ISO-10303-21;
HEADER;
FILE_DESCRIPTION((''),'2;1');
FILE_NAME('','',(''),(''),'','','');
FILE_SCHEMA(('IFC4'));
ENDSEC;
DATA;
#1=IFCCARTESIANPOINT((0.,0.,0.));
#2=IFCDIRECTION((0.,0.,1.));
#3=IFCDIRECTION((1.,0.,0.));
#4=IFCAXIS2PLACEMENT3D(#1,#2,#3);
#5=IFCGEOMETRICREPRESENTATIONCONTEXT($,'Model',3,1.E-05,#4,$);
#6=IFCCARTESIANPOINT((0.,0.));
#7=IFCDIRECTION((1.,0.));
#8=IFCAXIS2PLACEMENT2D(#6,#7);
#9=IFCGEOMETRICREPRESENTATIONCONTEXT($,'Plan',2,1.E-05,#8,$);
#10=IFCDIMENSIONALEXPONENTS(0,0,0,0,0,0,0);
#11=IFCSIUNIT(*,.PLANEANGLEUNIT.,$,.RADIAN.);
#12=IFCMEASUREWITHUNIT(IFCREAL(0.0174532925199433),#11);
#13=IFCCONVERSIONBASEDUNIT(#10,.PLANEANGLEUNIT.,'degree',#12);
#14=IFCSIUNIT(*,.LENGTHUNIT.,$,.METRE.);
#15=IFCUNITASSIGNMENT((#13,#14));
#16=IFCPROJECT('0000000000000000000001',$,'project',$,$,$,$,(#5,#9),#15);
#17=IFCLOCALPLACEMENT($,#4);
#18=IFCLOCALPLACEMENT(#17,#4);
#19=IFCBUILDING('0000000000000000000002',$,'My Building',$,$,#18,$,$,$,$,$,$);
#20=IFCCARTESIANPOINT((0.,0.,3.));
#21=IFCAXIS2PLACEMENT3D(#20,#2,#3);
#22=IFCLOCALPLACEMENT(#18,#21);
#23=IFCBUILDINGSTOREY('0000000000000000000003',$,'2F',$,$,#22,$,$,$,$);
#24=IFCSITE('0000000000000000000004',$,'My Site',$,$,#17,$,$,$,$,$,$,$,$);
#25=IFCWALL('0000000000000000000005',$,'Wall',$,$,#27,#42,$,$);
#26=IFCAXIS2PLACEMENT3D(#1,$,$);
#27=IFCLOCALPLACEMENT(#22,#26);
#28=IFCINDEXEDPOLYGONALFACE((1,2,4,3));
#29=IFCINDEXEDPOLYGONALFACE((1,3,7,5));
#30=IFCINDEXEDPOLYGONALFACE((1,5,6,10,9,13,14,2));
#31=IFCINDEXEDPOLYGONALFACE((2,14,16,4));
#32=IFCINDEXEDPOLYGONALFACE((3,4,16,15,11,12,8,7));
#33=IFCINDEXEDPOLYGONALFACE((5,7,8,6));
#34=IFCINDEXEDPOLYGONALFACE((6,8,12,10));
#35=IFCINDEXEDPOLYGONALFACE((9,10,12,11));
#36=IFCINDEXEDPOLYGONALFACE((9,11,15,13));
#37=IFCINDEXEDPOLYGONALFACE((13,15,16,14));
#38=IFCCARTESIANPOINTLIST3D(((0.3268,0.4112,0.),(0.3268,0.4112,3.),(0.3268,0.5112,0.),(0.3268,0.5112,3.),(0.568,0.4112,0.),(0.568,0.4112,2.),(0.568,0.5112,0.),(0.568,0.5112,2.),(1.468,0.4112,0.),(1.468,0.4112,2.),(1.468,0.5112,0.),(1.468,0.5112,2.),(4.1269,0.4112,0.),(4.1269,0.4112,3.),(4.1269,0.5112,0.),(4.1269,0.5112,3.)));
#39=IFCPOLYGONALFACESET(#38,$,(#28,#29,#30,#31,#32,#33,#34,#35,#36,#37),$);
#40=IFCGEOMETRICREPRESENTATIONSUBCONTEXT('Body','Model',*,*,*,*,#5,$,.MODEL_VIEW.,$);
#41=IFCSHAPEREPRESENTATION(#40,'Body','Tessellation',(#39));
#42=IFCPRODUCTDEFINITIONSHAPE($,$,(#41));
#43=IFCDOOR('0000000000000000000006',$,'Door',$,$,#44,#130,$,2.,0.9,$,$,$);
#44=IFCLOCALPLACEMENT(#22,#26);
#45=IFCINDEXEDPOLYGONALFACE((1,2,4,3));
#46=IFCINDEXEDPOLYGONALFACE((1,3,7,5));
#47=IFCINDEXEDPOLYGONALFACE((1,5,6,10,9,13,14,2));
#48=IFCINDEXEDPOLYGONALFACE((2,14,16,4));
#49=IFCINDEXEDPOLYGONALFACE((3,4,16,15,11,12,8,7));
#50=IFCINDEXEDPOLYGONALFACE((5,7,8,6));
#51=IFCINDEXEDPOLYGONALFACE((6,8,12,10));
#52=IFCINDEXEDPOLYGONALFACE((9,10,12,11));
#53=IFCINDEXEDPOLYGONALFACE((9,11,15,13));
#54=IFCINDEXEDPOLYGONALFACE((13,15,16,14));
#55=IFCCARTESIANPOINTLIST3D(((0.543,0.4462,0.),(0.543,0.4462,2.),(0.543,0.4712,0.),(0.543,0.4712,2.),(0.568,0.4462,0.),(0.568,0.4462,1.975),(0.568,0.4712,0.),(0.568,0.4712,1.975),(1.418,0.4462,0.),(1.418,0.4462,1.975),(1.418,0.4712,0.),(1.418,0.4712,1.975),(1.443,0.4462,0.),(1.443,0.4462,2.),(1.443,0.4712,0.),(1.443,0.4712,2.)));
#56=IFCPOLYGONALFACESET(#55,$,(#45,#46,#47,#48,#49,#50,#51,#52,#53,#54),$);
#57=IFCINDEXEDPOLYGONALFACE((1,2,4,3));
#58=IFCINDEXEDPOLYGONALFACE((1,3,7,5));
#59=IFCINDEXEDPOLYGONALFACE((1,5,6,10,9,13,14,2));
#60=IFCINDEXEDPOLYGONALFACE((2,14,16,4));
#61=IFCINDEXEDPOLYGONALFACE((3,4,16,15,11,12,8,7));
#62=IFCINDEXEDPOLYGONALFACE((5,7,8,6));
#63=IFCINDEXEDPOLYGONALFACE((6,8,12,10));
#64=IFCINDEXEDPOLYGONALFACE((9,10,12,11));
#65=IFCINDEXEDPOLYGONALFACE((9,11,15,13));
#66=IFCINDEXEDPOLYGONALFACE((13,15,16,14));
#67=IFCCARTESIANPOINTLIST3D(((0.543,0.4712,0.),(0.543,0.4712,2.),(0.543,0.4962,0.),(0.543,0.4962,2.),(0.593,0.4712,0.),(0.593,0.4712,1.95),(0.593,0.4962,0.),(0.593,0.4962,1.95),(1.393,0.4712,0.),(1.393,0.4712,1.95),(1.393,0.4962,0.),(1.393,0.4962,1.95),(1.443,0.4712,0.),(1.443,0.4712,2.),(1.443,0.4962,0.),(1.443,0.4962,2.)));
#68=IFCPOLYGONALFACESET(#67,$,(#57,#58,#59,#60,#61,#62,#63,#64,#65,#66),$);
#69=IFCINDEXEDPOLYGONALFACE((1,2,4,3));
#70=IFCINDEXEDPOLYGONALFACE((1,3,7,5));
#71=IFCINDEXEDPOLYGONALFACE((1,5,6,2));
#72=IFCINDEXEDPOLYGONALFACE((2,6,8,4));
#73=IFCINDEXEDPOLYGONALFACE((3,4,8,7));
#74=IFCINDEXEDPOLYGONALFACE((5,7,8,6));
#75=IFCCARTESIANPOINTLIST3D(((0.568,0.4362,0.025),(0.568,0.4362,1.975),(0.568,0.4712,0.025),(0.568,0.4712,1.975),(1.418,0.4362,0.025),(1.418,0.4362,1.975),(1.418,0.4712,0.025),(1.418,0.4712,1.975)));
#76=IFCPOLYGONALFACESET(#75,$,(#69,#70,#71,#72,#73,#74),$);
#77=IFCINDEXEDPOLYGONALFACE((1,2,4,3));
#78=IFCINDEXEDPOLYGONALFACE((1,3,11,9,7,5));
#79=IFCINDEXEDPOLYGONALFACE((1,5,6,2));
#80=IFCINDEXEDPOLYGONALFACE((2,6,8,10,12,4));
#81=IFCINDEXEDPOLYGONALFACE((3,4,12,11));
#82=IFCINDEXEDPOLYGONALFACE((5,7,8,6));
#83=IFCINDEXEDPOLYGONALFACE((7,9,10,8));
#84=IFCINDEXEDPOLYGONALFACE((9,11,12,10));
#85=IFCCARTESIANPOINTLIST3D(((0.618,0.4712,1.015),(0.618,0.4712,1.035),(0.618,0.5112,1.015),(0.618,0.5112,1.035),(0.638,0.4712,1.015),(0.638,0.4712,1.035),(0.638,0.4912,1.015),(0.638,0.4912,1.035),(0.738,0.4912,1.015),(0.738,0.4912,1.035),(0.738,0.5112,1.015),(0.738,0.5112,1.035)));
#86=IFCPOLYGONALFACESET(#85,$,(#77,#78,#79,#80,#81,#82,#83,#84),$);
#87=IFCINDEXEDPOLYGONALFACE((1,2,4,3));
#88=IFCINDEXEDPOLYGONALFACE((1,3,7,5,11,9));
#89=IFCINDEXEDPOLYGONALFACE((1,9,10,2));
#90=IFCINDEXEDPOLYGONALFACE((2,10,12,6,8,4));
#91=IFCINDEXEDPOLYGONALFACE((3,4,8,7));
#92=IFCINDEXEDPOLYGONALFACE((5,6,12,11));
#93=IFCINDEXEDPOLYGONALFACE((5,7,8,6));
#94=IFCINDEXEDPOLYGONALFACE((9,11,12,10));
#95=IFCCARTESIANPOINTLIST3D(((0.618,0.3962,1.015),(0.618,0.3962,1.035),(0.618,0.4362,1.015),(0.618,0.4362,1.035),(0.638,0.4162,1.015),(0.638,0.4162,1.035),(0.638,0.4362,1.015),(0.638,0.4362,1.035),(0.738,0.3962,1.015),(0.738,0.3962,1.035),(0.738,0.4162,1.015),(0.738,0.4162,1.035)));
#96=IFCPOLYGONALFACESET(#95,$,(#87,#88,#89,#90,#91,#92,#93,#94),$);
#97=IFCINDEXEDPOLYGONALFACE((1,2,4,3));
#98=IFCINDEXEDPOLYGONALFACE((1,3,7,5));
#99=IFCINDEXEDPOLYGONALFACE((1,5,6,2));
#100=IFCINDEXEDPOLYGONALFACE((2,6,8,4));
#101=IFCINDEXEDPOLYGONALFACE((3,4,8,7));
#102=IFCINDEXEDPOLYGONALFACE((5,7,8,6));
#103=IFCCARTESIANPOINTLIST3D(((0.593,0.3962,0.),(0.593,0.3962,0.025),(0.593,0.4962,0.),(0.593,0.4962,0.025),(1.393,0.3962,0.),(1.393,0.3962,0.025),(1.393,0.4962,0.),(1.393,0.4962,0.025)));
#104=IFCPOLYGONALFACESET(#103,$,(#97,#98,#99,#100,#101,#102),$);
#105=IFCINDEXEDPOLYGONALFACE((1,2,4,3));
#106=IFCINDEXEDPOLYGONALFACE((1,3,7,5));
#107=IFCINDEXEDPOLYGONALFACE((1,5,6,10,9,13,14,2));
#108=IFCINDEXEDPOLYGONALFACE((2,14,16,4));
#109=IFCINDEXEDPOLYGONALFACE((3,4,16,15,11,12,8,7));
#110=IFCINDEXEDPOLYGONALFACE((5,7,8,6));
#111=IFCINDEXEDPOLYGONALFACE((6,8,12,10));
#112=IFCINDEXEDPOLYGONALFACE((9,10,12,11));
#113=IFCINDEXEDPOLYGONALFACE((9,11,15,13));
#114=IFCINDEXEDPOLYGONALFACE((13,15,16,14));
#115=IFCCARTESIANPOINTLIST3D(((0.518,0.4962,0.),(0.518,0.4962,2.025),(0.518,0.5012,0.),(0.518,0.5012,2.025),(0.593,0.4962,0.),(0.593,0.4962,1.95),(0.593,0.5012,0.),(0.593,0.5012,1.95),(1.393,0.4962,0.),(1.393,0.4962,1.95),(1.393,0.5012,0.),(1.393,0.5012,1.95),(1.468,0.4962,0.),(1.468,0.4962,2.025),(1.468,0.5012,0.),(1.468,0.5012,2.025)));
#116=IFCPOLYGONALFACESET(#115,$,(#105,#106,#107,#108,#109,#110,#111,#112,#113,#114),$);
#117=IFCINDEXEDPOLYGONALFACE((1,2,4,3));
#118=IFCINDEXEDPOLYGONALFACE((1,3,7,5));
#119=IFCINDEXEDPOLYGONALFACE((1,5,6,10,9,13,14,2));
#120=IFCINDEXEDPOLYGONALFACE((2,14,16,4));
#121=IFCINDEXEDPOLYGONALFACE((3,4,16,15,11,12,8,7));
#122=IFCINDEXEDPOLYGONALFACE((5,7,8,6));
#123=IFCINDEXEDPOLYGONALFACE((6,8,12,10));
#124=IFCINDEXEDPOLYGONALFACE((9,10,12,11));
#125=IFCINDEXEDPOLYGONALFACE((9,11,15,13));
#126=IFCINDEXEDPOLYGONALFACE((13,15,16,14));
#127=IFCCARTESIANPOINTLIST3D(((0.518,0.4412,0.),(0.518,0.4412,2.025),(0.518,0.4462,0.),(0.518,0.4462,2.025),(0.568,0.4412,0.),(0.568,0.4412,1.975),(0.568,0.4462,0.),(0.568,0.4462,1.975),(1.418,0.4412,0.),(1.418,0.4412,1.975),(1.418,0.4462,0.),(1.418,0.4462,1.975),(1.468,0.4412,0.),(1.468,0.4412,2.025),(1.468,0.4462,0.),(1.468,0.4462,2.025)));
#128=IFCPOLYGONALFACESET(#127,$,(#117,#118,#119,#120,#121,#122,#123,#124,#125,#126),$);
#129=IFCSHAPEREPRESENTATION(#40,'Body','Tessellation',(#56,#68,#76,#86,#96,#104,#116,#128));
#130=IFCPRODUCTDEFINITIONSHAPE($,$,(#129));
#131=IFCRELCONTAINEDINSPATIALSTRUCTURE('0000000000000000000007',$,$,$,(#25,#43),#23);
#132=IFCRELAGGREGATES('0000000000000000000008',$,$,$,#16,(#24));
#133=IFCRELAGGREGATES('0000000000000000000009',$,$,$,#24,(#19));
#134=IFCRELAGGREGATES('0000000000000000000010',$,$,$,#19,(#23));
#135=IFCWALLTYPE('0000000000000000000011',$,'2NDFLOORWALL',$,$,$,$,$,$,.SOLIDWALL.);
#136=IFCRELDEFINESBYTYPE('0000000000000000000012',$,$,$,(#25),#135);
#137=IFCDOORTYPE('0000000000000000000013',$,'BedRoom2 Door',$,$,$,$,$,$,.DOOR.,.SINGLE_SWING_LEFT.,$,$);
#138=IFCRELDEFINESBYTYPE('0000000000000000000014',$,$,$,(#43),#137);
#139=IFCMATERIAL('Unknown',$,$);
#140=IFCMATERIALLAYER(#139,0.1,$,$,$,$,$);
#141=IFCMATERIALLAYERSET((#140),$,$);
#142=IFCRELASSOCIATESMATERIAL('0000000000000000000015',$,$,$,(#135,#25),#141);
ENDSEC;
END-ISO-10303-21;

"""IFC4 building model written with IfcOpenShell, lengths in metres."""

from ifc_helpers import new_model, entity, si_unit, converted_unit, frame, origin_with_axes, origin_2d_with_axis, place, context, subcontext, project, spatial, line, indexed_curve, outline, extrude, shape, source, transform, mapped, material, layer, layer_set, layer_usage, type_object, type_shapes, element, fill, save


model = new_model("IFC4")

# Units and contexts
model_context = context("Model", 3, precision=1e-05, world=origin_with_axes())
plan_context = context("Plan", 2, precision=1e-05, world=origin_2d_with_axis())
body_context_1 = subcontext(model_context, "Body", "Model", "MODEL_VIEW")
body_context_2 = subcontext(plan_context, "Body", "Plan", "PLAN_VIEW")
ifc_project = project(units=[converted_unit("PLANEANGLEUNIT", "degree", entity("IfcReal", 0.0174532925199433), si_unit("PLANEANGLEUNIT", "RADIAN"), dimensions=[0, 0, 0, 0, 0, 0, 0]), si_unit("LENGTHUNIT", "METRE")], contexts=[model_context, plan_context])

# Site, building, storey
site_placement = place(None, origin_with_axes())
site = spatial("IfcSite", under=ifc_project, at=site_placement, Name="My Site")
building_placement = place(site_placement, origin_with_axes())
building = spatial("IfcBuilding", under=site, at=building_placement, Name="My Building")
storey_placement = place(building_placement, frame((0.0, 0.0, 3.0), z_axis=(0.0, 0.0, 1.0), x_axis=(1.0, 0.0, 0.0)))
storey = spatial("IfcBuildingStorey", under=building, at=storey_placement, Name="2F")

# Shared definitions
ifc_material = material(Name="Unknown")

# Shared definitions
ifc_layer_1 = layer(ifc_material, 0.1)
ifc_layer_set_1 = layer_set([ifc_layer_1])
wall_type_1 = type_object("IfcWallType", Name="2NDFLOORWALL", PredefinedType="SOLIDWALL", material=ifc_layer_set_1)

# Wall, opening, door
ifc_layer_usage_1 = layer_usage(ifc_layer_set_1, "AXIS2", "POSITIVE", 0.0)
wall_1_placement = place(storey_placement, frame((0.3268, 0.4112, 0.0), z_axis=(0.0, 0.0, 1.0), x_axis=(1.0, 0.0, 0.0)))
wall_1 = element("IfcWall", 1, at=wall_1_placement, inside=storey, type_object=wall_type_1, material=ifc_layer_usage_1, Name="Wall", context=body_context_1, shape_type="SweptSolid", body=[
    extrude(outline(indexed_curve([(0.0, 0.0), (0.0, 0.1), (3.8001, 0.1), (3.8001, 0.0)], segments=[line(1, 2, 3, 4, 1)])), origin_with_axes(), (0.0, 0.0, 1.0), 3.0),
])
shared_shape_1 = source(origin_with_axes(), body_context_1, "Body", "SweptSolid", [
    extrude(outline(indexed_curve([(0.0, 0.0), (0.9, 0.0), (0.9, 2.0), (0.0, 2.0)], segments=[line(1, 2, 3, 4, 1)])), frame((0.0, -0.6, 0.0), z_axis=(0.0, -1.0, 0.0), x_axis=(1.0, 0.0, 0.0)), (0.0, 0.0, -1.0), 1.2),
])
opening_1_placement = place(wall_1_placement, frame((0.2412, 0.0, 0.0), z_axis=(0.0, 0.0, 1.0), x_axis=(1.0, 0.0, 0.0)))
opening_1 = element("IfcOpeningElement", 2, at=opening_1_placement, cuts=wall_1, PredefinedType="OPENING", context=body_context_1, shape_type="MappedRepresentation", body=[
    mapped(shared_shape_1, transform((0.0, 0.0, 0.0), x_axis=(1.0, 0.0, 0.0), y_axis=(0.0, 1.0, 0.0), z_axis=(0.0, 0.0, 1.0), scale=1.0)),
])
door_type_1 = type_object("IfcDoorType", Name="BedRoom2 Door", OperationType="SINGLE_SWING_LEFT", PredefinedType="DOOR")
shared_shape_2 = source(origin_with_axes(), body_context_1, "Body", "SweptSolid", [
    extrude(outline(indexed_curve([(0.0, 0.0), (0.0, 2.0), (0.9, 2.0), (0.9, 0.0), (0.875, 0.0), (0.875, 1.975), (0.025, 1.975), (0.025, 0.0)], segments=[line(1, 2, 3, 4, 5, 6, 7, 8, 1)])), frame((0.0, 0.025, 0.0), z_axis=(0.0, -1.0, 0.0), x_axis=(1.0, 0.0, 0.0)), (0.0, 0.0, -1.0), 0.025),
    extrude(outline(indexed_curve([(0.0, 0.0), (0.0, 2.0), (0.9, 2.0), (0.9, 0.0), (0.85, 0.0), (0.85, 1.95), (0.05, 1.95), (0.05, 0.0)], segments=[line(1, 2, 3, 4, 5, 6, 7, 8, 1)])), frame((0.0, 0.0, 0.0), z_axis=(0.0, -1.0, 0.0), x_axis=(1.0, 0.0, 0.0)), (0.0, 0.0, -1.0), 0.025),
    extrude(outline(indexed_curve([(0.0, 0.0), (0.85, 0.0), (0.85, 0.035), (0.0, 0.035)], segments=[line(1, 2, 3, 4, 1)])), frame((0.025, 0.025, 0.025), z_axis=(0.0, 0.0, 1.0), x_axis=(1.0, 0.0, 0.0)), (0.0, 0.0, 1.0), 1.95),
    extrude(outline(indexed_curve([(0.0, 0.0), (0.0, -0.04), (-0.12, -0.04), (-0.12, -0.02), (-0.02, -0.02), (-0.02, 0.0)], segments=[line(1, 2, 3, 4, 5, 6, 1)])), frame((0.825, 0.025, 1.015), z_axis=(0.0, 0.0, 1.0), x_axis=(1.0, 0.0, 0.0)), (0.0, 0.0, 1.0), 0.02),
    extrude(outline(indexed_curve([(0.0, 0.0), (0.0, 0.04), (-0.12, 0.04), (-0.12, 0.02), (-0.02, 0.02), (-0.02, 0.0)], segments=[line(1, 2, 3, 4, 5, 6, 1)])), frame((0.825, 0.06, 1.015), z_axis=(0.0, 0.0, 1.0), x_axis=(1.0, 0.0, 0.0)), (0.0, 0.0, 1.0), 0.02),
    extrude(outline(indexed_curve([(0.0, 0.0), (0.8, 0.0), (0.8, 0.1), (0.0, 0.1)], segments=[line(1, 2, 3, 4, 1)])), frame((0.05, 0.0, 0.0), z_axis=(0.0, 0.0, 1.0), x_axis=(1.0, 0.0, 0.0)), (0.0, 0.0, 1.0), 0.025),
    extrude(outline(indexed_curve([(0.0, 0.0), (0.0, 2.025), (0.95, 2.025), (0.95, 0.0), (0.875, 0.0), (0.875, 1.95), (0.075, 1.95), (0.075, 0.0)], segments=[line(1, 2, 3, 4, 5, 6, 7, 8, 1)])), frame((-0.025, -0.005, 0.0), z_axis=(0.0, -1.0, 0.0), x_axis=(1.0, 0.0, 0.0)), (0.0, 0.0, -1.0), 0.005),
    extrude(outline(indexed_curve([(0.0, 0.0), (0.0, 2.025), (0.95, 2.025), (0.95, 0.0), (0.9, 0.0), (0.9, 1.975), (0.05, 1.975), (0.05, 0.0)], segments=[line(1, 2, 3, 4, 5, 6, 7, 8, 1)])), frame((-0.025, 0.05, 0.0), z_axis=(0.0, -1.0, 0.0), x_axis=(1.0, 0.0, 0.0)), (0.0, 0.0, -1.0), 0.005),
])
shared_shape_3 = source(origin_with_axes(), body_context_2, "Body", "Curve2D", [
    entity("IfcIndexedPolyCurve", entity("IfcCartesianPointList2D", [[0.0, 0.0], [0.0, 0.05], [0.025, 0.05], [0.025, 0.025], [0.05, 0.025], [0.05, 0.0]]), [entity("IfcLineIndex", [1, 2, 3, 4, 5, 6, 1])]),
    entity("IfcIndexedPolyCurve", entity("IfcCartesianPointList2D", [[0.9, 0.0], [0.9, 0.05], [0.875, 0.05], [0.875, 0.025], [0.85, 0.025], [0.85, 0.0]]), [entity("IfcLineIndex", [1, 2, 3, 4, 5, 6, 1])]),
    entity("IfcTrimmedCurve", entity("IfcEllipse", entity("IfcAxis2Placement2D", entity("IfcCartesianPoint", [0.06, 0.05]), entity("IfcDirection", [1.0, 0.0])), 0.815, 0.85), [entity("IfcCartesianPoint", [0.875, 0.05])], [entity("IfcCartesianPoint", [0.06, 0.9])], True, "CARTESIAN"),
    entity("IfcIndexedPolyCurve", entity("IfcCartesianPointList2D", [[0.025, 0.05], [0.06, 0.05], [0.06, 0.9], [0.025, 0.9]]), [entity("IfcLineIndex", [1, 2, 3, 4, 1])]),
])
type_shapes(door_type_1, [shared_shape_2, shared_shape_3])
door_1_placement = place(opening_1_placement, frame((0.875, 0.085, 0.0), z_axis=(0.0, 0.0, 1.0), x_axis=(-1.0, 0.0, 0.0)))
door_1 = element("IfcDoor", 3, at=door_1_placement, inside=storey, type_object=door_type_1, Name="Door", OverallHeight=2.0, OverallWidth=0.9, shapes=[
    shape(body_context_1, "Body", "MappedRepresentation", [mapped(shared_shape_2, transform((0.0, 0.0, 0.0), x_axis=(1.0, 0.0, 0.0), y_axis=(0.0, 1.0, 0.0), z_axis=(0.0, 0.0, 1.0), scale=1.0))]),
    shape(body_context_2, "Body", "MappedRepresentation", [mapped(shared_shape_3, transform((0.0, 0.0, 0.0), x_axis=(1.0, 0.0, 0.0), y_axis=(0.0, 1.0, 0.0), z_axis=(0.0, 0.0, 1.0), scale=1.0))]),
])
fill(opening_1, door_1)

save(model, "model.ifc")
